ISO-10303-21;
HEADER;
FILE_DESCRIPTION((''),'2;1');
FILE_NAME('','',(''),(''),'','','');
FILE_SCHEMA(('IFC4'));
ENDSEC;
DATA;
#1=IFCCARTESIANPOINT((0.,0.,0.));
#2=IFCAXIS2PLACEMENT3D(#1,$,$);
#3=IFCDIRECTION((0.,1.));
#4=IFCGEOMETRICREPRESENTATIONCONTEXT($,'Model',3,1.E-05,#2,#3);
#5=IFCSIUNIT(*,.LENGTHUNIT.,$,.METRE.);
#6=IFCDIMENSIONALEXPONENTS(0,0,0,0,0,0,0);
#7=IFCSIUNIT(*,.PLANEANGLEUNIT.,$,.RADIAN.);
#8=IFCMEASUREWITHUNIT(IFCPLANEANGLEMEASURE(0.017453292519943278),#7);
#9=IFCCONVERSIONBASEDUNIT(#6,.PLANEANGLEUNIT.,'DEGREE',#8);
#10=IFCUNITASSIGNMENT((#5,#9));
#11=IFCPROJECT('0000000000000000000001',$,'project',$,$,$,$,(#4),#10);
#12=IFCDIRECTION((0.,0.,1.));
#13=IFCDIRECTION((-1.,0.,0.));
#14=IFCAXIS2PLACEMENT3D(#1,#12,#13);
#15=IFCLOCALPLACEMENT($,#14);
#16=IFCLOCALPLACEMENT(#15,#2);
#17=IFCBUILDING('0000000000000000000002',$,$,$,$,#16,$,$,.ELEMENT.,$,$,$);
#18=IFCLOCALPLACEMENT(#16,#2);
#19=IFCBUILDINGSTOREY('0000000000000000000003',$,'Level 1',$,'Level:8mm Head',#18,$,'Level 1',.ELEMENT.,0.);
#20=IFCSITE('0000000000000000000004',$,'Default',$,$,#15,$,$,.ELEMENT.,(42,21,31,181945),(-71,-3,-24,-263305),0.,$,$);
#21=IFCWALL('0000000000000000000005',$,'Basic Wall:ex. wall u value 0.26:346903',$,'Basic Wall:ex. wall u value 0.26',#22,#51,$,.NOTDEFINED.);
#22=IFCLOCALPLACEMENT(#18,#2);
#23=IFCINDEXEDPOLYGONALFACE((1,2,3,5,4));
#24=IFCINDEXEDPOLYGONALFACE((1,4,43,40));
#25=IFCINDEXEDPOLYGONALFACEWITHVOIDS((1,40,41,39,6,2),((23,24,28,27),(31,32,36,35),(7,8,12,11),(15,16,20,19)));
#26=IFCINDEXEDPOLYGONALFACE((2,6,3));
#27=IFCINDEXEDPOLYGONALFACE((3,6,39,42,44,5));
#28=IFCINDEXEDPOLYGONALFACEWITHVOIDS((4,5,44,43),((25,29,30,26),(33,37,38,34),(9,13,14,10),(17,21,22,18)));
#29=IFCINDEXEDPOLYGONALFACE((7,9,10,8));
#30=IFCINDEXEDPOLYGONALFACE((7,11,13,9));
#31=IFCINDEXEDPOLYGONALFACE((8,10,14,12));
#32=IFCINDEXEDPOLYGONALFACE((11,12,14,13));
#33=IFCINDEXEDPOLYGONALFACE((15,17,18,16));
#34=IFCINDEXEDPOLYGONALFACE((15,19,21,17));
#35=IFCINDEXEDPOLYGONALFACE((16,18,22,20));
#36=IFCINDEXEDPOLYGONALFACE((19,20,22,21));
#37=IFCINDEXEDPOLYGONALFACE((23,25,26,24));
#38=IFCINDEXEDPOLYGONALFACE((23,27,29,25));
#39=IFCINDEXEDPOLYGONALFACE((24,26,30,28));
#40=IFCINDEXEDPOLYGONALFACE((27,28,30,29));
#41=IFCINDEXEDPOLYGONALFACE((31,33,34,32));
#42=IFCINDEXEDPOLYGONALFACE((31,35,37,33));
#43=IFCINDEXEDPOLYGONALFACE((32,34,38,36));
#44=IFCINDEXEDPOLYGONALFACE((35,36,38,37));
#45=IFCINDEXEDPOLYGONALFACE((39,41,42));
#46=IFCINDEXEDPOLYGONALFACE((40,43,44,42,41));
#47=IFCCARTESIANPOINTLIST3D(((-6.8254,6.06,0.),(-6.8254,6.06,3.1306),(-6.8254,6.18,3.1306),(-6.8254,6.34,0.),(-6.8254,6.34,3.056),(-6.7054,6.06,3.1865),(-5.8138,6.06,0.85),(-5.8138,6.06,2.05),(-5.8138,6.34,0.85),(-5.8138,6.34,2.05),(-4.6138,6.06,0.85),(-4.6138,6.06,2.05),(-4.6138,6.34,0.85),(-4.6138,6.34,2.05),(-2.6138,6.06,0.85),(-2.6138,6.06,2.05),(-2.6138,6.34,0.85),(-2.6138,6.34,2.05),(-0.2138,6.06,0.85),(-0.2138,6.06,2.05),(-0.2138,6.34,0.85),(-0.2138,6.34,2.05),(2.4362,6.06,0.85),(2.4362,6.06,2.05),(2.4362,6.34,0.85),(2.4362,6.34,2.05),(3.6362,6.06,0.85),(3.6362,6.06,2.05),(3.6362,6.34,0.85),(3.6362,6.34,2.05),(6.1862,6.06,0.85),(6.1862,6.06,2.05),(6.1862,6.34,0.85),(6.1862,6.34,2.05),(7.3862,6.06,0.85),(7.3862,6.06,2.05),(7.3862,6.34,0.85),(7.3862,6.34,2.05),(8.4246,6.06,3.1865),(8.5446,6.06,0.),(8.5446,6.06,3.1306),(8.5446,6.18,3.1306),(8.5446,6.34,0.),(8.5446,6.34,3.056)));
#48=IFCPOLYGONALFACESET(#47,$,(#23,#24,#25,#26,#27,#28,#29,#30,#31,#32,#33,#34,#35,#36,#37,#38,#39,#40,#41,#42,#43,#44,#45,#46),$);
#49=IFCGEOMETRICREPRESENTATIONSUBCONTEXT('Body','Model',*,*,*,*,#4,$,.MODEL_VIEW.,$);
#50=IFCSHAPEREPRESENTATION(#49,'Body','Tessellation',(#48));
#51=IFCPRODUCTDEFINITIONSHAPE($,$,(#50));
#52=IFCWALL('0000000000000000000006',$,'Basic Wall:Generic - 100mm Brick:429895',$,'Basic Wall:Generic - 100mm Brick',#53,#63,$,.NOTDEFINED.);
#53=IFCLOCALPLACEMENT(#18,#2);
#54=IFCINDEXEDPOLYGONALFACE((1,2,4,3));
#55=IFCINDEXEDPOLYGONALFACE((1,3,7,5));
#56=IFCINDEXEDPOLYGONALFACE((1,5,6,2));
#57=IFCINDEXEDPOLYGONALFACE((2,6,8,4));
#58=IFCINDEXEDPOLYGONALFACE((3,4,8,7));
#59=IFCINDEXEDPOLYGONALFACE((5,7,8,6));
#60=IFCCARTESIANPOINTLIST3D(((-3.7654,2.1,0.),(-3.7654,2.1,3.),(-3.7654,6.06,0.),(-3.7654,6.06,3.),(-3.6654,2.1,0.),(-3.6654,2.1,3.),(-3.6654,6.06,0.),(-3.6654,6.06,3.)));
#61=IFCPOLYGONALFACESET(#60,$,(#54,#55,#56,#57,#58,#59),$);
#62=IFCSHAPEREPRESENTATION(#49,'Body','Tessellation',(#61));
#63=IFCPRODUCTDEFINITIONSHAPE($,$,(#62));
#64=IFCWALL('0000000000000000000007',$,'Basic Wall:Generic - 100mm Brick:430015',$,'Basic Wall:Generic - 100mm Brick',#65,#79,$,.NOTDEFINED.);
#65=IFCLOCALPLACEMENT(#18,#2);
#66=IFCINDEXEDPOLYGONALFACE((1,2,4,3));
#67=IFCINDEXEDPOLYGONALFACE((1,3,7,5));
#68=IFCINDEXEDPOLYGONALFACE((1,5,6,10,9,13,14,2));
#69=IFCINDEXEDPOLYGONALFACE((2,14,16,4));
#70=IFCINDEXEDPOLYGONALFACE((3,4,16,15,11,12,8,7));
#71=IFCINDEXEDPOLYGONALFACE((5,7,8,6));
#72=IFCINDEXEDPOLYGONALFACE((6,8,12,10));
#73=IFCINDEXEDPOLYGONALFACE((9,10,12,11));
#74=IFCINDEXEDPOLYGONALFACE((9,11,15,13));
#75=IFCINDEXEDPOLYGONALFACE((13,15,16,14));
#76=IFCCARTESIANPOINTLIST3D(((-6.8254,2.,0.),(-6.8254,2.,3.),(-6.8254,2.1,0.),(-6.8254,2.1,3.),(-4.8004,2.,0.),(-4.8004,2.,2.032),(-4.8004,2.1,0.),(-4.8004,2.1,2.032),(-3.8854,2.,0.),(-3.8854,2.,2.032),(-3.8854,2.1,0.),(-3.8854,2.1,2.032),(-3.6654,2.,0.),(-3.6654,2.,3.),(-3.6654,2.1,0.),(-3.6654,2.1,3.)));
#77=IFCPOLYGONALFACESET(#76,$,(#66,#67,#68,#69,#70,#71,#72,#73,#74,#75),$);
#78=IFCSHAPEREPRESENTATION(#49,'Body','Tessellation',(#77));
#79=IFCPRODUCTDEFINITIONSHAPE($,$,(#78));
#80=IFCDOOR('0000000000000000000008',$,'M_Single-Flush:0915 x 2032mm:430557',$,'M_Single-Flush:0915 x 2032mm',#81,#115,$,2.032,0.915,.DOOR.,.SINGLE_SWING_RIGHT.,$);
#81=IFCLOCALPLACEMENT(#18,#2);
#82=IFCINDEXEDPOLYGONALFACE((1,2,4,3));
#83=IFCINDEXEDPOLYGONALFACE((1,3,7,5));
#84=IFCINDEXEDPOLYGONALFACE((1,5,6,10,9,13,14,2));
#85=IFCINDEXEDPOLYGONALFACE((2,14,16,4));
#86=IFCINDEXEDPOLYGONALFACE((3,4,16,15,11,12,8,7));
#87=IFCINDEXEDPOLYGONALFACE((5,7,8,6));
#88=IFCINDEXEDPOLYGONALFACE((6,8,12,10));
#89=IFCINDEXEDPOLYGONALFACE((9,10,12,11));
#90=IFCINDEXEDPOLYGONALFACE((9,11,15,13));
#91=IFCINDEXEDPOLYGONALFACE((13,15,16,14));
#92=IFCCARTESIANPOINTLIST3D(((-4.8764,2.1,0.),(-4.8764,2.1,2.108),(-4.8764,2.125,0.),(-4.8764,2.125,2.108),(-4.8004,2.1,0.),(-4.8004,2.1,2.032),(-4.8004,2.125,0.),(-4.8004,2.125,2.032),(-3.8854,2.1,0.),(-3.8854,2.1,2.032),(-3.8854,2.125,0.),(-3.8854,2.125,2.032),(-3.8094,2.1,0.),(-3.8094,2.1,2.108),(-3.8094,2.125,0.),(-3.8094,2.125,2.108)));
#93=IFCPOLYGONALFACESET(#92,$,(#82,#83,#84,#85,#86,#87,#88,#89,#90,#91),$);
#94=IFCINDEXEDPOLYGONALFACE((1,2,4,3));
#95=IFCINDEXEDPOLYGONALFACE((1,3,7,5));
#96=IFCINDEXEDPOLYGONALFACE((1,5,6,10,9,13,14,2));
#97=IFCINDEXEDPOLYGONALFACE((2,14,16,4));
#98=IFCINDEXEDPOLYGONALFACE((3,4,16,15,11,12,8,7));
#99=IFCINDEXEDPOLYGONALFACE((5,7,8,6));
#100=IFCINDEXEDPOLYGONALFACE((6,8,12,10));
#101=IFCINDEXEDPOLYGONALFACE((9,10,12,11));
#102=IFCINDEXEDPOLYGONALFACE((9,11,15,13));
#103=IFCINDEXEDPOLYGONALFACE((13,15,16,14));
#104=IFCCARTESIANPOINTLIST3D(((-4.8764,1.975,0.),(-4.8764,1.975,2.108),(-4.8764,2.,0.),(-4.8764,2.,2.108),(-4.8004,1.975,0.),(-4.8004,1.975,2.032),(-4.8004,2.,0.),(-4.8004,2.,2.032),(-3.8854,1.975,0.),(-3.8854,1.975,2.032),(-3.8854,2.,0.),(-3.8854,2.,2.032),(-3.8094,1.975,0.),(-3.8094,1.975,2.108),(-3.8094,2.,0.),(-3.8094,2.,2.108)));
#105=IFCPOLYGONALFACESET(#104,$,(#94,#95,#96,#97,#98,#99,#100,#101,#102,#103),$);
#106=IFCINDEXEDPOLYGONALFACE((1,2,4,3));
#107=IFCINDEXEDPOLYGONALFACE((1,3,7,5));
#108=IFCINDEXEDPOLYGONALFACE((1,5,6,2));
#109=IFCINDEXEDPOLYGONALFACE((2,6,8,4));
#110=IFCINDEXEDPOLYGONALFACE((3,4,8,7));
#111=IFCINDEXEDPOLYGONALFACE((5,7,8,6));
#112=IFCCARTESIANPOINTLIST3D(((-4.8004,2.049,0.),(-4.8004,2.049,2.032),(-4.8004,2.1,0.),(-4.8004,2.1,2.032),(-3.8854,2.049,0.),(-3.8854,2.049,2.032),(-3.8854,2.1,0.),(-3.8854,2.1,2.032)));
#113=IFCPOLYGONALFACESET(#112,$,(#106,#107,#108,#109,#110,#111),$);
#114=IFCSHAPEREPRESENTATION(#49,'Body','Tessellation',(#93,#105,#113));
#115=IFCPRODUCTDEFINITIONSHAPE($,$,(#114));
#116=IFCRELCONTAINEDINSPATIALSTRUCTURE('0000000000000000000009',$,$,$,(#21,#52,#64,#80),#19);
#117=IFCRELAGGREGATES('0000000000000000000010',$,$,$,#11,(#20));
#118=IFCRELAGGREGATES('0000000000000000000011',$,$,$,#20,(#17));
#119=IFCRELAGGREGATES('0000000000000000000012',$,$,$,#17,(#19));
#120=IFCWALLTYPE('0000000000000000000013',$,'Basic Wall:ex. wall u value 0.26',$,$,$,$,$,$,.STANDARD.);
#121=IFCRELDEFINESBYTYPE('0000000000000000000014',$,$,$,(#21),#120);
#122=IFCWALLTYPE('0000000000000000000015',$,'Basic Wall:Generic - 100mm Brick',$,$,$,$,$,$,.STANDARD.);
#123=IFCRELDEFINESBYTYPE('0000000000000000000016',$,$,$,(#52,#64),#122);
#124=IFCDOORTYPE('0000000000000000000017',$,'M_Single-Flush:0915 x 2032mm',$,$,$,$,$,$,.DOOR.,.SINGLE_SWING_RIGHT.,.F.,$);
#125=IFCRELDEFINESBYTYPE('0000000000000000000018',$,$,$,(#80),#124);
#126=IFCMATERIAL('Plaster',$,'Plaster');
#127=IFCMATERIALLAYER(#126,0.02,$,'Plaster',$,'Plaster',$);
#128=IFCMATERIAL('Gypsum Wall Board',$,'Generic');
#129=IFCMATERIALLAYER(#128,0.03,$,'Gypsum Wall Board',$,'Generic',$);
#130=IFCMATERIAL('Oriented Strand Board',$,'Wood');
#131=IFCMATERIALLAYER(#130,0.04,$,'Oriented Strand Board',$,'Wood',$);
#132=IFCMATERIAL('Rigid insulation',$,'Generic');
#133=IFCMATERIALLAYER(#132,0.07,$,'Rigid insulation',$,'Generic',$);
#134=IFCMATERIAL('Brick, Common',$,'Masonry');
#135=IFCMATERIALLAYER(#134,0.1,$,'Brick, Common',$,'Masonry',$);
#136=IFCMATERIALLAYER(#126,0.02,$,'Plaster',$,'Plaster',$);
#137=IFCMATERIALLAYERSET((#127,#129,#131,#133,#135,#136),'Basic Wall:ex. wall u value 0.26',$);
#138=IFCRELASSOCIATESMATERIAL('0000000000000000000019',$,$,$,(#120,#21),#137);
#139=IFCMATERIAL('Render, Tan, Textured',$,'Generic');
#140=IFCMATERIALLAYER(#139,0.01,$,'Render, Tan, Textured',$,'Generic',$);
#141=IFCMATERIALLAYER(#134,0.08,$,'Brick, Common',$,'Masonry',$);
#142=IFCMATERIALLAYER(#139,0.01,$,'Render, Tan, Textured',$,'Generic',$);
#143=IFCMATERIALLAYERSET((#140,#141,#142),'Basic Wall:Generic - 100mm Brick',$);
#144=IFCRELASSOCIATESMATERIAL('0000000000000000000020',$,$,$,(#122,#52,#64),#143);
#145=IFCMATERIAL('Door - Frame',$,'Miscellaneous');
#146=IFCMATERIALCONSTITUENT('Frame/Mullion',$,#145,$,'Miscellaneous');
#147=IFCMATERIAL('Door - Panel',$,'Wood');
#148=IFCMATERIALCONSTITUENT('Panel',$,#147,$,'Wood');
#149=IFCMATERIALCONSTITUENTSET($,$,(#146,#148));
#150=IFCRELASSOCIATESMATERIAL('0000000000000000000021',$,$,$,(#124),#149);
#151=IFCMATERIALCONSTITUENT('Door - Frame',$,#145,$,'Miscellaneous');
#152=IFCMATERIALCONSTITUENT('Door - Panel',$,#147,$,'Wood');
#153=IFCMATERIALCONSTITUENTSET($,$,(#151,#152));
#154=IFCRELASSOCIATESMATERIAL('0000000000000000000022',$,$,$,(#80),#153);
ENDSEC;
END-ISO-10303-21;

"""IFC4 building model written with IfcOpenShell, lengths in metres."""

from ifc_helpers import new_model, entity, si_unit, converted_unit, direction, frame, frame_2d, origin, place, context, subcontext, project, spatial, polyline, rectangle, outline, extrude, clip, bounded_halfspace, source, transform, mapped, material, layer, layer_set, layer_usage, constituent, constituent_set, type_object, type_shapes, element, fill, save


model = new_model("IFC4")

# Units and contexts
model_context = context("Model", 3, precision=1e-05, world=origin(), true_north=direction((0.0, 1.0)))
body_context = subcontext(model_context, "Body", "Model", "MODEL_VIEW")
ifc_project = project(units=[si_unit("LENGTHUNIT", "METRE"), converted_unit("PLANEANGLEUNIT", "DEGREE", entity("IfcPlaneAngleMeasure", 0.017453292519943278), si_unit("PLANEANGLEUNIT", "RADIAN"), dimensions=[0, 0, 0, 0, 0, 0, 0])], contexts=[model_context])

# Site, building, storey
site_placement = place(None, frame((0.0, 0.0, 0.0), z_axis=(0.0, 0.0, 1.0), x_axis=(-1.0, 0.0, 0.0)))
site = spatial("IfcSite", under=ifc_project, at=site_placement, Name="Default", CompositionType="ELEMENT", RefLatitude=(42, 21, 31, 181945), RefLongitude=(-71, -3, -24, -263305), RefElevation=0.0)
building_placement = place(site_placement, origin())
building = spatial("IfcBuilding", under=site, at=building_placement, CompositionType="ELEMENT")
storey_placement = place(building_placement, origin())
storey = spatial("IfcBuildingStorey", under=building, at=storey_placement, Name="Level 1", ObjectType="Level:8mm Head", LongName="Level 1", CompositionType="ELEMENT", Elevation=0.0)

# Shared definitions
ifc_material_1 = material(Name="Rigid insulation", Category="Generic")

# Wall, openings
ifc_material_2 = material(Name="Plaster", Category="Plaster")
ifc_layer_1 = layer(ifc_material_2, 0.02, Name="Plaster", Category="Plaster")
ifc_material_3 = material(Name="Gypsum Wall Board", Category="Generic")
ifc_layer_2 = layer(ifc_material_3, 0.03, Name="Gypsum Wall Board", Category="Generic")
ifc_material_4 = material(Name="Oriented Strand Board", Category="Wood")
ifc_layer_3 = layer(ifc_material_4, 0.04, Name="Oriented Strand Board", Category="Wood")
ifc_layer_4 = layer(ifc_material_1, 0.07, Name="Rigid insulation", Category="Generic")
ifc_material_5 = material(Name="Brick, Common", Category="Masonry")
ifc_layer_5 = layer(ifc_material_5, 0.1, Name="Brick, Common", Category="Masonry")
ifc_layer_6 = layer(ifc_material_2, 0.02, Name="Plaster", Category="Plaster")
ifc_layer_set_1 = layer_set([ifc_layer_1, ifc_layer_2, ifc_layer_3, ifc_layer_4, ifc_layer_5, ifc_layer_6], Name="Basic Wall:ex. wall u value 0.26")
ifc_layer_usage_1 = layer_usage(ifc_layer_set_1, "AXIS2", "POSITIVE", -0.14)
wall_type_1 = type_object("IfcWallType", Name="Basic Wall:ex. wall u value 0.26", PredefinedType="STANDARD", material=ifc_layer_set_1)
wall_1_placement = place(storey_placement, frame((8.5446, 6.2, 0.0), z_axis=(0.0, 0.0, 1.0), x_axis=(-1.0, 0.0, 0.0)))
wall_1 = element("IfcWall", 1, at=wall_1_placement, inside=storey, type_object=wall_type_1, material=ifc_layer_usage_1, Name="Basic Wall:ex. wall u value 0.26:346903", ObjectType="Basic Wall:ex. wall u value 0.26", PredefinedType="NOTDEFINED", context=body_context, shape_type="Clipping", body=[
    clip(clip(clip(extrude(rectangle(XDim=15.37, YDim=0.28, at=frame_2d((7.685, 0.0), x_axis=(-1.0, 0.0))), origin(), (0.0, 0.0, 1.0), 3.1865), bounded_halfspace(frame((0.0, -0.14, 3.056), z_axis=(0.0, -0.422618, 0.906308), x_axis=(1.0, 0.0, 0.0)), False, frame((0.0, -0.14, 3.056)), polyline([(0.0, 0.0), (15.37, 0.0), (15.37, 0.16), (15.25, 0.28), (0.12, 0.28), (0.0, 0.16), (0.0, 0.0)]))), bounded_halfspace(frame((15.37, 0.02, 3.1306), z_axis=(0.422618, 0.0, 0.906308), x_axis=(0.0, 1.0, 0.0)), False, frame((15.37, 0.02, 3.1306)), polyline([(0.0, 0.0), (0.0, 0.12), (-0.12, 0.12), (0.0, 0.0)]))), bounded_halfspace(frame((0.12, 0.14, 3.1865), z_axis=(-0.422618, 0.0, 0.906308), x_axis=(0.0, -1.0, 0.0)), False, frame((0.12, 0.14, 3.1865)), polyline([(0.0, 0.0), (-0.12, 0.0), (-0.12, -0.12), (0.0, 0.0)]))),
])
opening_1_placement = place(wall_1_placement, frame((14.3584, 0.14, 0.85)))
element("IfcOpeningElement", 2, at=opening_1_placement, cuts=wall_1, PredefinedType="OPENING", context=body_context, shape_type="SweptSolid", body=[
    extrude(rectangle(XDim=1.2, YDim=1.2, at=frame_2d((0.6, 0.6), x_axis=(1.0, 0.0))), frame((0.0, 0.0, 0.0), z_axis=(0.0, -1.0, 0.0), x_axis=(0.0, 0.0, 1.0)), (0.0, 0.0, 1.0), 0.28),
])
opening_2_placement = place(wall_1_placement, frame((11.1584, 0.14, 0.85)))
element("IfcOpeningElement", 3, at=opening_2_placement, cuts=wall_1, PredefinedType="OPENING", context=body_context, shape_type="SweptSolid", body=[
    extrude(rectangle(XDim=1.2, YDim=2.4, at=frame_2d((0.6, 1.2), x_axis=(1.0, 0.0))), frame((0.0, 0.0, 0.0), z_axis=(0.0, -1.0, 0.0), x_axis=(0.0, 0.0, 1.0)), (0.0, 0.0, 1.0), 0.28),
])
opening_3_placement = place(wall_1_placement, frame((6.1084, 0.14, 0.85)))
element("IfcOpeningElement", 4, at=opening_3_placement, cuts=wall_1, PredefinedType="OPENING", context=body_context, shape_type="SweptSolid", body=[
    extrude(rectangle(XDim=1.2, YDim=1.2, at=frame_2d((0.6, 0.6), x_axis=(1.0, 0.0))), frame((0.0, 0.0, 0.0), z_axis=(0.0, -1.0, 0.0), x_axis=(0.0, 0.0, 1.0)), (0.0, 0.0, 1.0), 0.28),
])
opening_4_placement = place(wall_1_placement, frame((2.3584, 0.14, 0.85)))
element("IfcOpeningElement", 5, at=opening_4_placement, cuts=wall_1, PredefinedType="OPENING", context=body_context, shape_type="SweptSolid", body=[
    extrude(rectangle(XDim=1.2, YDim=1.2, at=frame_2d((0.6, 0.6), x_axis=(1.0, 0.0))), frame((0.0, 0.0, 0.0), z_axis=(0.0, -1.0, 0.0), x_axis=(0.0, 0.0, 1.0)), (0.0, 0.0, 1.0), 0.28),
])

# Wall
ifc_material_6 = material(Name="Render, Tan, Textured", Category="Generic")
ifc_layer_7 = layer(ifc_material_6, 0.01, Name="Render, Tan, Textured", Category="Generic")
ifc_layer_8 = layer(ifc_material_5, 0.08, Name="Brick, Common", Category="Masonry")
ifc_layer_9 = layer(ifc_material_6, 0.01, Name="Render, Tan, Textured", Category="Generic")
ifc_layer_set_2 = layer_set([ifc_layer_7, ifc_layer_8, ifc_layer_9], Name="Basic Wall:Generic - 100mm Brick")
ifc_layer_usage_2 = layer_usage(ifc_layer_set_2, "AXIS2", "NEGATIVE", 0.05)
wall_type_2 = type_object("IfcWallType", Name="Basic Wall:Generic - 100mm Brick", PredefinedType="STANDARD", material=ifc_layer_set_2)
wall_2_placement = place(storey_placement, frame((-3.7154, 6.06, 0.0), z_axis=(0.0, 0.0, 1.0), x_axis=(0.0, -1.0, 0.0)))
element("IfcWall", 6, at=wall_2_placement, inside=storey, type_object=wall_type_2, material=ifc_layer_usage_2, Name="Basic Wall:Generic - 100mm Brick:429895", ObjectType="Basic Wall:Generic - 100mm Brick", PredefinedType="NOTDEFINED", context=body_context, shape_type="SweptSolid", body=[
    extrude(rectangle(XDim=3.96, YDim=0.1, at=frame_2d((1.98, 0.0), x_axis=(-1.0, 0.0))), origin(), (0.0, 0.0, 1.0), 3.0),
])

# Wall, opening, door
wall_3_placement = place(storey_placement, frame((-6.8254, 2.05, 0.0)))
wall_3 = element("IfcWall", 7, at=wall_3_placement, inside=storey, type_object=wall_type_2, material=ifc_layer_usage_2, Name="Basic Wall:Generic - 100mm Brick:430015", ObjectType="Basic Wall:Generic - 100mm Brick", PredefinedType="NOTDEFINED", context=body_context, shape_type="SweptSolid", body=[
    extrude(rectangle(XDim=3.16, YDim=0.1, at=frame_2d((1.58, 0.0), x_axis=(-1.0, 0.0))), origin(), (0.0, 0.0, 1.0), 3.0),
])
opening_5_placement = place(wall_3_placement, frame((2.025, -0.05, 0.0)))
opening_5 = element("IfcOpeningElement", 8, at=opening_5_placement, cuts=wall_3, PredefinedType="OPENING", context=body_context, shape_type="SweptSolid", body=[
    extrude(rectangle(XDim=0.915, YDim=2.032, at=frame_2d((1.016, 0.4575), x_axis=(0.0, 1.0))), frame((0.0, 0.0, 0.0), z_axis=(0.0, 1.0, 0.0), x_axis=(0.0, 0.0, 1.0)), (0.0, 0.0, 1.0), 0.1),
])
ifc_material_7 = material(Name="Door - Frame", Category="Miscellaneous")
ifc_constituent_1 = constituent(ifc_material_7, Name="Door - Frame", Category="Miscellaneous")
ifc_material_8 = material(Name="Door - Panel", Category="Wood")
ifc_constituent_2 = constituent(ifc_material_8, Name="Door - Panel", Category="Wood")
ifc_constituent_set_1 = constituent_set(constituents=[ifc_constituent_1, ifc_constituent_2])
ifc_constituent_3 = constituent(ifc_material_7, Name="Frame/Mullion", Category="Miscellaneous")
ifc_constituent_4 = constituent(ifc_material_8, Name="Panel", Category="Wood")
ifc_constituent_set_2 = constituent_set(constituents=[ifc_constituent_3, ifc_constituent_4])
door_type_1 = type_object("IfcDoorType", Name="M_Single-Flush:0915 x 2032mm", OperationType="SINGLE_SWING_RIGHT", ParameterTakesPrecedence=False, PredefinedType="DOOR", material=ifc_constituent_set_2)
shared_shape_1 = source(origin(), body_context, "Body", "SweptSolid", [
    extrude(outline(polyline([(-0.5335, -1.073), (0.5335, -1.073), (0.5335, 1.035), (0.4575, 1.035), (0.4575, -0.997), (-0.4575, -0.997), (-0.4575, 1.035), (-0.5335, 1.035), (-0.5335, -1.073)])), frame((0.4575, 0.1, 1.035), z_axis=(0.0, 1.0, 0.0), x_axis=(1.0, 0.0, 0.0)), (0.0, 0.0, 1.0), 0.025),
    extrude(outline(polyline([(-1.073, -0.5335), (1.035, -0.5335), (1.035, -0.4575), (-0.997, -0.4575), (-0.997, 0.4575), (1.035, 0.4575), (1.035, 0.5335), (-1.073, 0.5335), (-1.073, -0.5335)])), frame((0.4575, -0.025, 1.035), z_axis=(0.0, 1.0, 0.0), x_axis=(0.0, 0.0, -1.0)), (0.0, 0.0, 1.0), 0.025),
    extrude(rectangle(XDim=0.051, YDim=0.915, at=frame_2d((0.0, 0.0), x_axis=(1.0, 0.0))), frame((0.4575, 0.0745, 0.0), z_axis=(0.0, 0.0, 1.0), x_axis=(0.0, 1.0, 0.0)), (0.0, 0.0, 1.0), 2.032),
])
type_shapes(door_type_1, [shared_shape_1])
door_1_placement = place(opening_5_placement, origin())
door_1 = element("IfcDoor", 9, at=door_1_placement, inside=storey, type_object=door_type_1, material=ifc_constituent_set_1, Name="M_Single-Flush:0915 x 2032mm:430557", ObjectType="M_Single-Flush:0915 x 2032mm", OperationType="SINGLE_SWING_RIGHT", OverallHeight=2.032, OverallWidth=0.915, PredefinedType="DOOR", context=body_context, shape_type="MappedRepresentation", body=[
    mapped(shared_shape_1, transform((0.0, 0.0, 0.0), scale=1.0)),
])
fill(opening_5, door_1)

save(model, "model.ifc")
